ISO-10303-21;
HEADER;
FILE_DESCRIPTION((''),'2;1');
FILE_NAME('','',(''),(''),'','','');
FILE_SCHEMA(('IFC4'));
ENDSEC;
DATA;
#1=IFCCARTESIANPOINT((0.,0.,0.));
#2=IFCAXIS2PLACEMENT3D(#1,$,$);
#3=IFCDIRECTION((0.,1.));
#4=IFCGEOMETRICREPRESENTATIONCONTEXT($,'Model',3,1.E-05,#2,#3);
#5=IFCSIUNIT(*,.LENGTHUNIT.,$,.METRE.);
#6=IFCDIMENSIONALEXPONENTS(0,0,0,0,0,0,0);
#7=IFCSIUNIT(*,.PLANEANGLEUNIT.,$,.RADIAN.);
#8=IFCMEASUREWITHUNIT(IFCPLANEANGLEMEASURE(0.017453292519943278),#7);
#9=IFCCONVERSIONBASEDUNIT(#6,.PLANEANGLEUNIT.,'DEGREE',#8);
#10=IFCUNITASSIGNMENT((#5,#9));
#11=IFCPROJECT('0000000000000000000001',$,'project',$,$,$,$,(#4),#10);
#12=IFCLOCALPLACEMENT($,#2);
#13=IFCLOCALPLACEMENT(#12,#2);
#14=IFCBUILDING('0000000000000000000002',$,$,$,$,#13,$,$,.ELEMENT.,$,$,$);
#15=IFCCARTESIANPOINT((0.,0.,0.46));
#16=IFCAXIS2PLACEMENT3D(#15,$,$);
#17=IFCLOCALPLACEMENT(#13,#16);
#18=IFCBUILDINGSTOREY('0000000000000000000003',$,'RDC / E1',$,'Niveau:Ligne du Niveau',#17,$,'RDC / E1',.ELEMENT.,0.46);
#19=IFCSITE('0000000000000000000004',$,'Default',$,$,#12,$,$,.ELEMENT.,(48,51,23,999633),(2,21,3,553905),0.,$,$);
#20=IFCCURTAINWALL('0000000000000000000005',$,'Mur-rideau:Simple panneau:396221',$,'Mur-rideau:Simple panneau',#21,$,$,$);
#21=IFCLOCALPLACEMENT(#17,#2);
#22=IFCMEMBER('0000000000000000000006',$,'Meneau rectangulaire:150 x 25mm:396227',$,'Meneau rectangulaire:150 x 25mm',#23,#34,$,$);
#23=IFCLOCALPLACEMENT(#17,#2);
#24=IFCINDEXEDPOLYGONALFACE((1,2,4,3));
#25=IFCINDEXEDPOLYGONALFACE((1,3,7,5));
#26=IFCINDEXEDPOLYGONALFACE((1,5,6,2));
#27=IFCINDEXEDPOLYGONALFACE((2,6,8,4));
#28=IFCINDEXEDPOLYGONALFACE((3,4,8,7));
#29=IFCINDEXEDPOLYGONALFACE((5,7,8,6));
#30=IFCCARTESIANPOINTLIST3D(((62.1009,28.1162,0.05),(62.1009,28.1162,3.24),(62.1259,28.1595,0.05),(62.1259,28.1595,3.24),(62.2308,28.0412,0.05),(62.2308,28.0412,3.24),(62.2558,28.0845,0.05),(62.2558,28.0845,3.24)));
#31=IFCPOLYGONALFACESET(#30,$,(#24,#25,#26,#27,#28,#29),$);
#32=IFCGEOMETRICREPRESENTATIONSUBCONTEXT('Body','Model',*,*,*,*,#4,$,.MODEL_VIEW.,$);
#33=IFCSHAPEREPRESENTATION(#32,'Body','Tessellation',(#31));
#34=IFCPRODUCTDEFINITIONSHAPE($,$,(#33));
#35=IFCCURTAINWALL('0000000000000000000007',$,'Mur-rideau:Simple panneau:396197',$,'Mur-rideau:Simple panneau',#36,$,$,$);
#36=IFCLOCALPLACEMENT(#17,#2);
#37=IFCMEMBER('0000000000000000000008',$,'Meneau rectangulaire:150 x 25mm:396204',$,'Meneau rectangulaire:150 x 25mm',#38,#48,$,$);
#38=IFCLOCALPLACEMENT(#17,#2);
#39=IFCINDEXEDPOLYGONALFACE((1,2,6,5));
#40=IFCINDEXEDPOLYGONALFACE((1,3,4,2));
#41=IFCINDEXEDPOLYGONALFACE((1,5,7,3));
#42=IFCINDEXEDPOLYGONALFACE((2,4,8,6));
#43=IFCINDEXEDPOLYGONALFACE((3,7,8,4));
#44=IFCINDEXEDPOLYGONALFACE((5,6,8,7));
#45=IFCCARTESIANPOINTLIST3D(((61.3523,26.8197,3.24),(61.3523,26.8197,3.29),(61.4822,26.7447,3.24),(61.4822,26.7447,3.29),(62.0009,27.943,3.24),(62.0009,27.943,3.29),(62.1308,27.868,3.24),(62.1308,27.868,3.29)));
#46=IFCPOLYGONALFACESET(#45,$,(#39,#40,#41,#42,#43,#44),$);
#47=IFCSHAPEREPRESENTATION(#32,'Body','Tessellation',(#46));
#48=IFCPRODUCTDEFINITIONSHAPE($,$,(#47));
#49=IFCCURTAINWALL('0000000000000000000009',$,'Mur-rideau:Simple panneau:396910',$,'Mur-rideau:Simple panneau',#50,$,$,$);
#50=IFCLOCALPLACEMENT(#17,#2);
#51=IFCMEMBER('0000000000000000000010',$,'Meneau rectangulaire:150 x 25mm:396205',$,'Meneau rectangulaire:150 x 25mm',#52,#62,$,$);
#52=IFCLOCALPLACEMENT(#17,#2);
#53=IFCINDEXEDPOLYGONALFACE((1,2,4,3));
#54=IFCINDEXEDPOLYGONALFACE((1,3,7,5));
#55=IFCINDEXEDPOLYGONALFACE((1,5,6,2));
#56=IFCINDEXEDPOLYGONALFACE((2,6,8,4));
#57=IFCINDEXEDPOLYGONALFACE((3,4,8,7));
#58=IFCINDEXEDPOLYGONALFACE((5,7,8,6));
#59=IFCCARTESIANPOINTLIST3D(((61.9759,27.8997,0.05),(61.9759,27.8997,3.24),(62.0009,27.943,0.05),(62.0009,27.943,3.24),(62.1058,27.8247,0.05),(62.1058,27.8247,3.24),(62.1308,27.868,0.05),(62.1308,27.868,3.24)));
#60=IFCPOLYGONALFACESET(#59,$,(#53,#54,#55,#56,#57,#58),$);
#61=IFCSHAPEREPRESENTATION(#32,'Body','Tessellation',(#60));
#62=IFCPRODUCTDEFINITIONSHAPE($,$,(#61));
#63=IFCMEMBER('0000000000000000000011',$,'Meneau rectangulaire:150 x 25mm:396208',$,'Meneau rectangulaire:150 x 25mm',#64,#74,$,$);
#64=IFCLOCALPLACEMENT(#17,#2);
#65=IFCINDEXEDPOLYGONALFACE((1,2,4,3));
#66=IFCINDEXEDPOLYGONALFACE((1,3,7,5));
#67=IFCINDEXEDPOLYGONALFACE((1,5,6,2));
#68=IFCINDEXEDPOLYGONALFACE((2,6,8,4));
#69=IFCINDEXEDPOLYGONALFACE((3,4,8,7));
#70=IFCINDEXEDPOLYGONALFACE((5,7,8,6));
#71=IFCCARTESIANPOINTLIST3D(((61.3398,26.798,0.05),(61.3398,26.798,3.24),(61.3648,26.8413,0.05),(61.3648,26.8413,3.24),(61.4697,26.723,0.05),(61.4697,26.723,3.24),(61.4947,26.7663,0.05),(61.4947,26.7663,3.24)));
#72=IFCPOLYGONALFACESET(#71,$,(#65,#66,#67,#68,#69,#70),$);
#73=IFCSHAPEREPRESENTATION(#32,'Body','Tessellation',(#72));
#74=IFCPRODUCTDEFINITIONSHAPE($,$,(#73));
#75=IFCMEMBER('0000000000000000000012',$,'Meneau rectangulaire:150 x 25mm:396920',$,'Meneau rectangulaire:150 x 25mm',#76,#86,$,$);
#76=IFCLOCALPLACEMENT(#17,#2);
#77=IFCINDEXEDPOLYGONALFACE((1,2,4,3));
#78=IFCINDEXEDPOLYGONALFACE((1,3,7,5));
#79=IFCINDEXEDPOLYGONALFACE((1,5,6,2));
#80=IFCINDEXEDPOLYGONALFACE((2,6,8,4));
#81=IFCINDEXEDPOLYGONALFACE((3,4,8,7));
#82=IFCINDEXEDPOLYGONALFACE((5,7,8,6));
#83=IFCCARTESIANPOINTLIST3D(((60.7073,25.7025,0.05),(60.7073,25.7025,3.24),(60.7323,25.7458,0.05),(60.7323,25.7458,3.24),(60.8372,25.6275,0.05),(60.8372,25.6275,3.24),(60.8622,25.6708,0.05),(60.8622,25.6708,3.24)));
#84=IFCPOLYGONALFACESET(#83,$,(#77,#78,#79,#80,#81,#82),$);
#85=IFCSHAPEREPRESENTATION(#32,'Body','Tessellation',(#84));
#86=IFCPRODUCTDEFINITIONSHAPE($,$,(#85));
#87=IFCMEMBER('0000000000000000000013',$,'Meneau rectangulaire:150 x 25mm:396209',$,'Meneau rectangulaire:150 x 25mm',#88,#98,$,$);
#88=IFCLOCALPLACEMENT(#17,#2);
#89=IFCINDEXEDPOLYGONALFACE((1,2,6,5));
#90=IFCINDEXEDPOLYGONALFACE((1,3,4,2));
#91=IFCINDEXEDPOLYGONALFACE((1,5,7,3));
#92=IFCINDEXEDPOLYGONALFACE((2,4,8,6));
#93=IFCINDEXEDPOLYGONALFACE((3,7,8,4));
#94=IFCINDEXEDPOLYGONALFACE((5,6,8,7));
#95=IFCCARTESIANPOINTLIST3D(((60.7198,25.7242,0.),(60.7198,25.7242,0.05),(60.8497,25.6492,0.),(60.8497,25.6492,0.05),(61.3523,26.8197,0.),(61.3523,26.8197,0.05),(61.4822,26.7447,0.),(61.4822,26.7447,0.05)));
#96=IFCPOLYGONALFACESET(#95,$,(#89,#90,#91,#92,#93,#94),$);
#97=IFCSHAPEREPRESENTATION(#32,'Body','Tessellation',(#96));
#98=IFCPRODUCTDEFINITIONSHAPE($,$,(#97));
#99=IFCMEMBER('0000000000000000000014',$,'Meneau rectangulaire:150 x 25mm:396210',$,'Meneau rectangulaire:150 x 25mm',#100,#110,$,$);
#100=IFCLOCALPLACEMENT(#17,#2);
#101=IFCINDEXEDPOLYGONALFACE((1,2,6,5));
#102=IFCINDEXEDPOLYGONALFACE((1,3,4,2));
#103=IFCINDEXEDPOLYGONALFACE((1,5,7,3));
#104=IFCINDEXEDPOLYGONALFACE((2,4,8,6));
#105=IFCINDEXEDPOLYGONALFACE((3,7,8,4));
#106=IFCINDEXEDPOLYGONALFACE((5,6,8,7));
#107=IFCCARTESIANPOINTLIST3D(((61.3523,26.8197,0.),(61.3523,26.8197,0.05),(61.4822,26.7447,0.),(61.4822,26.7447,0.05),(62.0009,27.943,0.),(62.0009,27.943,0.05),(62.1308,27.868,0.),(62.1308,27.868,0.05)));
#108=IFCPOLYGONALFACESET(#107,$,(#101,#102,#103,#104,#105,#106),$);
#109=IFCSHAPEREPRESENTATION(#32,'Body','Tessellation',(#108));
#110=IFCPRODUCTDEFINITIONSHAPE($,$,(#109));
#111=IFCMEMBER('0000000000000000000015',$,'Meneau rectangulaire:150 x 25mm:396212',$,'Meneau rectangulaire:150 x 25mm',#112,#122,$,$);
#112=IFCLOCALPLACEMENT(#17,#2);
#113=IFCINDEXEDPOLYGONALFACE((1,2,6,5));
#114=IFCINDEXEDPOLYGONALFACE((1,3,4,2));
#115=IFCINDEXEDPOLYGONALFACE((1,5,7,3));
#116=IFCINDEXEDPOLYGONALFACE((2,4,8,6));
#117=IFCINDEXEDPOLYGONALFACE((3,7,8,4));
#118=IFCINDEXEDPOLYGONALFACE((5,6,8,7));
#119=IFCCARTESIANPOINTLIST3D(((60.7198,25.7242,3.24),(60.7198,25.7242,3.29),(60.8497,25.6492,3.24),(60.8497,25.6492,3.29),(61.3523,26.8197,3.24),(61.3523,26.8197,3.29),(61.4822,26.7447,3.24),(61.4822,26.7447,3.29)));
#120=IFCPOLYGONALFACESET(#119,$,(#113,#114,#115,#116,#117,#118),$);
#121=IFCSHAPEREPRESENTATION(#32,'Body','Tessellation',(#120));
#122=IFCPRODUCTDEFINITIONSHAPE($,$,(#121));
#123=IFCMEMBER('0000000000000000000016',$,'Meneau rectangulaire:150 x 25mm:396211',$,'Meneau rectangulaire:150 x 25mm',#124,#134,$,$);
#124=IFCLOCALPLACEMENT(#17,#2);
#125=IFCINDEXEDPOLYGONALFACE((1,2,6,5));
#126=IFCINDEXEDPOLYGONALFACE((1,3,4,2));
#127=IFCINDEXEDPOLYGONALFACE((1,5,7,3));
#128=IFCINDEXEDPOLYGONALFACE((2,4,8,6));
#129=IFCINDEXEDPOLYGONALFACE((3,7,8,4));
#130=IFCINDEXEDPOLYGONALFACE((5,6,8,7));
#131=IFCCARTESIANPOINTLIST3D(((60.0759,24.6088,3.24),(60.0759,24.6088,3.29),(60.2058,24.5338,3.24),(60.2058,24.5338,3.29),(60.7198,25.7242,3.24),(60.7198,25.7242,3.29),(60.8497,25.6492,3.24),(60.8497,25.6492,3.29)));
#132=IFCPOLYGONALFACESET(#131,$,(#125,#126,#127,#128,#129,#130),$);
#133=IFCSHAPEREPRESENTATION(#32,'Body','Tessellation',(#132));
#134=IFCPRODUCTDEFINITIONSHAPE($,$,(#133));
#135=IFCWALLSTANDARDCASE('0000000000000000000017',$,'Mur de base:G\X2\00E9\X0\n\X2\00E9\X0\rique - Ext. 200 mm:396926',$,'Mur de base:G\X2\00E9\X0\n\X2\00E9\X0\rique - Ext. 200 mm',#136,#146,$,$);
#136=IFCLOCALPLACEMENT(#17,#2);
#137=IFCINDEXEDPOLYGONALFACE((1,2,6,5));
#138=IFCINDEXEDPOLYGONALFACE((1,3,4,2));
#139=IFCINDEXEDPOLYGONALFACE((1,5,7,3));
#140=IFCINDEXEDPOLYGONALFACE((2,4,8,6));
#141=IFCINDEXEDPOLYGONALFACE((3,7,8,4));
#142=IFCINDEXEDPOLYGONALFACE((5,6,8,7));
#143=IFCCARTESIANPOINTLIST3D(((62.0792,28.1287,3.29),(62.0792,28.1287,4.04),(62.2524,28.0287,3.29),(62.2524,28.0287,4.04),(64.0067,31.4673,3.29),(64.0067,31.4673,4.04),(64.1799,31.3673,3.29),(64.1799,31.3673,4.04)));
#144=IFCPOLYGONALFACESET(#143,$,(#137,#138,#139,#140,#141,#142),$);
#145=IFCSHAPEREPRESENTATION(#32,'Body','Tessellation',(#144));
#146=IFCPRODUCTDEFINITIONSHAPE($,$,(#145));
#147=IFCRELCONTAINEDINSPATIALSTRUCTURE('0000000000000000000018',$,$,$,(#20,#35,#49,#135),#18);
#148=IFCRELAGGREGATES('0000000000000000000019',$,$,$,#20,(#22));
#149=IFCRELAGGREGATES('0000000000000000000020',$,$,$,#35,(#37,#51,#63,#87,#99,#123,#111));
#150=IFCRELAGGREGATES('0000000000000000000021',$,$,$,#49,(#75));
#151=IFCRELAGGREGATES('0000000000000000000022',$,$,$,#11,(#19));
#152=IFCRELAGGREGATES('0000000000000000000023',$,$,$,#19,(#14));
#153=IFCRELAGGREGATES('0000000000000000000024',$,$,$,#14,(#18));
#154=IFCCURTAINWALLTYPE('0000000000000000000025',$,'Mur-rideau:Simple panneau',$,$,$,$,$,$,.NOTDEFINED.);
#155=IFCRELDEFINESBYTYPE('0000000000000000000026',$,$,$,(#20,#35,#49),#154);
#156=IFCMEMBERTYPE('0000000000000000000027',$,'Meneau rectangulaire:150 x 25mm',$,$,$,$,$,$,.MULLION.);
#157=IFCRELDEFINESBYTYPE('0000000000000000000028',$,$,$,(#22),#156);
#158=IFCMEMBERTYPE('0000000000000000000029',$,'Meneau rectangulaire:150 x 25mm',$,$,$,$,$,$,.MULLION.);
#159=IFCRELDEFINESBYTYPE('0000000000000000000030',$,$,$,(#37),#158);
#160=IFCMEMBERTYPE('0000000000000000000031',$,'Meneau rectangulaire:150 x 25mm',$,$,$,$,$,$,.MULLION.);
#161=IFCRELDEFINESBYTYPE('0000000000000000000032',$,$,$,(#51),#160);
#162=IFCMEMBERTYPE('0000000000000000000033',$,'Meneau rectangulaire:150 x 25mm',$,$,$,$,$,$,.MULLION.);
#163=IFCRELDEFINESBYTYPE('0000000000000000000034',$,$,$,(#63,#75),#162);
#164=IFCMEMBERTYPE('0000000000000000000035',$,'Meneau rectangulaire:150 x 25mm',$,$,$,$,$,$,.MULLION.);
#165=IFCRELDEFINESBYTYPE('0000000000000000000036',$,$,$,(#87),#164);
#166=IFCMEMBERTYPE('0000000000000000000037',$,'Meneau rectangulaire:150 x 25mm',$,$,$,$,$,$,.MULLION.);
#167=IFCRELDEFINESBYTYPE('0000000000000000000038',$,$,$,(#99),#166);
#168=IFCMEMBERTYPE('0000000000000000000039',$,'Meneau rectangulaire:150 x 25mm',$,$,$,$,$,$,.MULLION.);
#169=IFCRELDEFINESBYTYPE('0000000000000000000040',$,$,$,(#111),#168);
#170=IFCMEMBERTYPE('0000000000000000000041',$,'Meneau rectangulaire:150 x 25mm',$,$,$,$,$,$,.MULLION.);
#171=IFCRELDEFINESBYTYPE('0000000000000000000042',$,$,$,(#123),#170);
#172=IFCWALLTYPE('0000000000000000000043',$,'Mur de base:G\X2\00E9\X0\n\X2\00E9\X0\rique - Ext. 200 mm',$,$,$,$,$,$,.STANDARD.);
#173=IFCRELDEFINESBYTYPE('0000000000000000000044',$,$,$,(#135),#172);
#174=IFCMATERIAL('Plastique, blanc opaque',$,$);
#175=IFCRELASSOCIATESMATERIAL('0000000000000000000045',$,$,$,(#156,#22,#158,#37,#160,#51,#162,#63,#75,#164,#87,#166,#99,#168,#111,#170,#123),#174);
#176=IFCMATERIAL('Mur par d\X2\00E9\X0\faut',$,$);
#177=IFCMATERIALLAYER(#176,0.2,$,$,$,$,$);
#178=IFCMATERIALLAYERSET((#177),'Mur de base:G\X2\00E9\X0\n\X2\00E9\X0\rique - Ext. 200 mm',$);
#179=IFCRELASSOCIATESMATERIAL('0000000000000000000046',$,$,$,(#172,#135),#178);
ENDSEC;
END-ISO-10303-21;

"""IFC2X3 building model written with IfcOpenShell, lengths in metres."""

from ifc_helpers import new_model, entity, si_unit, converted_unit, direction, frame, frame_2d, origin, origin_2d_with_axis, place, context, subcontext, project, spatial, rectangle, extrude, source, transform, mapped, material, layer, layer_set, layer_usage, type_object, type_shapes, element, aggregate, save


model = new_model("IFC2X3")

# Units and contexts
model_context = context("Model", 3, precision=1e-05, world=origin(), true_north=direction((0.0, 1.0)))
body_context = subcontext(model_context, "Body", "Model", "MODEL_VIEW")
ifc_project = project(units=[si_unit("LENGTHUNIT", "METRE"), converted_unit("PLANEANGLEUNIT", "DEGREE", entity("IfcPlaneAngleMeasure", 0.017453292519943278), si_unit("PLANEANGLEUNIT", "RADIAN"), dimensions=[0, 0, 0, 0, 0, 0, 0])], contexts=[model_context])

# Site, building, storey
site_placement = place(None, origin())
site = spatial("IfcSite", under=ifc_project, at=site_placement, Name="Default", CompositionType="ELEMENT", RefLatitude=(48, 51, 23, 999633), RefLongitude=(2, 21, 3, 553905), RefElevation=0.0)
building_placement = place(site_placement, origin())
building = spatial("IfcBuilding", under=site, at=building_placement, CompositionType="ELEMENT")
storey_placement = place(building_placement, frame((0.0, 0.0, 0.46)))
storey = spatial("IfcBuildingStorey", under=building, at=storey_placement, Name="RDC / E1", ObjectType="Niveau:Ligne du Niveau", LongName="RDC / E1", CompositionType="ELEMENT", Elevation=0.46)

# Curtain walls, members
curtain_wall_type = type_object("IfcCurtainWallType", Name="Mur-rideau:Simple panneau", PredefinedType="NOTDEFINED")
curtain_wall_1_placement = place(storey_placement, frame((0.0, 0.0, -0.46)))
curtain_wall_1 = element("IfcCurtainWall", 1, at=curtain_wall_1_placement, inside=storey, type_object=curtain_wall_type, Name="Mur-rideau:Simple panneau:396221", ObjectType="Mur-rideau:Simple panneau")
ifc_material_1 = material(Name="Plastique, blanc opaque")
member_type_1 = type_object("IfcMemberType", Name="Meneau rectangulaire:150 x 25mm", PredefinedType="MULLION", material=ifc_material_1)
shared_shape_1 = source(origin(), body_context, "Body", "SweptSolid", [
    extrude(rectangle(XDim=0.05, YDim=0.15, at=origin_2d_with_axis()), frame((-0.025, 0.0, -3.19), z_axis=(0.0, 0.0, 1.0), x_axis=(-1.0, 0.0, 0.0)), (0.0, 0.0, 1.0), 3.19),
])
type_shapes(member_type_1, [shared_shape_1])
member_1_placement = place(curtain_wall_1_placement, frame((62.1658, 28.0787, 3.7), z_axis=(0.0, 0.0, 1.0), x_axis=(-0.5, -0.866025, 0.0)))
member_1 = element("IfcMember", 2, at=member_1_placement, type_object=member_type_1, material=ifc_material_1, Name="Meneau rectangulaire:150 x 25mm:396227", ObjectType="Meneau rectangulaire:150 x 25mm", context=body_context, shape_type="MappedRepresentation", body=[
    mapped(shared_shape_1, transform((0.0, 0.0, 0.0), scale=1.0)),
])
aggregate(curtain_wall_1, [member_1])
curtain_wall_2_placement = place(storey_placement, frame((0.0, 0.0, -0.46)))
curtain_wall_2 = element("IfcCurtainWall", 3, at=curtain_wall_2_placement, inside=storey, type_object=curtain_wall_type, Name="Mur-rideau:Simple panneau:396197", ObjectType="Mur-rideau:Simple panneau")
member_type_2 = type_object("IfcMemberType", Name="Meneau rectangulaire:150 x 25mm", PredefinedType="MULLION", material=ifc_material_1)
shared_shape_2 = source(origin(), body_context, "Body", "SweptSolid", [
    extrude(rectangle(XDim=0.05, YDim=0.15, at=origin_2d_with_axis()), frame((-0.025, 0.0, -1.2971), z_axis=(0.0, 0.0, 1.0), x_axis=(-1.0, 0.0, 0.0)), (0.0, 0.0, 1.0), 1.2971),
])
type_shapes(member_type_2, [shared_shape_2])
member_2_placement = place(curtain_wall_2_placement, frame((62.0658, 27.9055, 3.75), z_axis=(0.5, 0.866025, 0.0), x_axis=(0.0, 0.0, 1.0)))
member_2 = element("IfcMember", 4, at=member_2_placement, type_object=member_type_2, material=ifc_material_1, Name="Meneau rectangulaire:150 x 25mm:396204", ObjectType="Meneau rectangulaire:150 x 25mm", context=body_context, shape_type="MappedRepresentation", body=[
    mapped(shared_shape_2, transform((0.0, 0.0, 0.0), scale=1.0)),
])
curtain_wall_3_placement = place(storey_placement, frame((0.0, 0.0, -0.46)))
curtain_wall_3 = element("IfcCurtainWall", 5, at=curtain_wall_3_placement, inside=storey, type_object=curtain_wall_type, Name="Mur-rideau:Simple panneau:396910", ObjectType="Mur-rideau:Simple panneau")

# Members
member_type_3 = type_object("IfcMemberType", Name="Meneau rectangulaire:150 x 25mm", PredefinedType="MULLION", material=ifc_material_1)
shared_shape_3 = source(origin(), body_context, "Body", "SweptSolid", [
    extrude(rectangle(XDim=0.05, YDim=0.15, at=origin_2d_with_axis()), frame((-0.025, 0.0, -3.19), z_axis=(0.0, 0.0, 1.0), x_axis=(-1.0, 0.0, 0.0)), (0.0, 0.0, 1.0), 3.19),
])
type_shapes(member_type_3, [shared_shape_3])
member_3_placement = place(curtain_wall_2_placement, frame((62.0658, 27.9055, 0.51), z_axis=(0.0, 0.0, -1.0), x_axis=(0.5, 0.866025, 0.0)))
member_3 = element("IfcMember", 6, at=member_3_placement, type_object=member_type_3, material=ifc_material_1, Name="Meneau rectangulaire:150 x 25mm:396205", ObjectType="Meneau rectangulaire:150 x 25mm", context=body_context, shape_type="MappedRepresentation", body=[
    mapped(shared_shape_3, transform((0.0, 0.0, 0.0), scale=1.0)),
])
member_type_4 = type_object("IfcMemberType", Name="Meneau rectangulaire:150 x 25mm", PredefinedType="MULLION", material=ifc_material_1)
shared_shape_4 = source(origin(), body_context, "Body", "SweptSolid", [
    extrude(rectangle(XDim=0.05, YDim=0.15, at=origin_2d_with_axis()), frame((0.0, 0.0, -3.19), z_axis=(0.0, 0.0, 1.0), x_axis=(-1.0, 0.0, 0.0)), (0.0, 0.0, 1.0), 3.19),
])
type_shapes(member_type_4, [shared_shape_4])
member_4_placement = place(curtain_wall_2_placement, frame((61.4172, 26.7822, 0.51), z_axis=(0.0, 0.0, -1.0), x_axis=(0.5, 0.866025, 0.0)))
member_4 = element("IfcMember", 7, at=member_4_placement, type_object=member_type_4, material=ifc_material_1, Name="Meneau rectangulaire:150 x 25mm:396208", ObjectType="Meneau rectangulaire:150 x 25mm", context=body_context, shape_type="MappedRepresentation", body=[
    mapped(shared_shape_4, transform((0.0, 0.0, 0.0), scale=1.0)),
])
member_5_placement = place(curtain_wall_3_placement, frame((60.7847, 25.6867, 0.51), z_axis=(0.0, 0.0, -1.0), x_axis=(0.5, 0.866025, 0.0)))
member_5 = element("IfcMember", 8, at=member_5_placement, type_object=member_type_4, material=ifc_material_1, Name="Meneau rectangulaire:150 x 25mm:396920", ObjectType="Meneau rectangulaire:150 x 25mm", context=body_context, shape_type="MappedRepresentation", body=[
    mapped(shared_shape_4, transform((0.0, 0.0, 0.0), scale=1.0)),
])
member_type_5 = type_object("IfcMemberType", Name="Meneau rectangulaire:150 x 25mm", PredefinedType="MULLION", material=ifc_material_1)
shared_shape_5 = source(origin(), body_context, "Body", "SweptSolid", [
    extrude(rectangle(XDim=0.05, YDim=0.15, at=origin_2d_with_axis()), frame((-0.025, 0.0, -1.265), z_axis=(0.0, 0.0, 1.0), x_axis=(-1.0, 0.0, 0.0)), (0.0, 0.0, 1.0), 1.265),
])
type_shapes(member_type_5, [shared_shape_5])
member_6_placement = place(curtain_wall_2_placement, frame((60.7847, 25.6867, 0.46), z_axis=(-0.5, -0.866025, 0.0), x_axis=(0.0, 0.0, -1.0)))
member_6 = element("IfcMember", 9, at=member_6_placement, type_object=member_type_5, material=ifc_material_1, Name="Meneau rectangulaire:150 x 25mm:396209", ObjectType="Meneau rectangulaire:150 x 25mm", context=body_context, shape_type="MappedRepresentation", body=[
    mapped(shared_shape_5, transform((0.0, 0.0, 0.0), scale=1.0)),
])
member_type_6 = type_object("IfcMemberType", Name="Meneau rectangulaire:150 x 25mm", PredefinedType="MULLION", material=ifc_material_1)
shared_shape_6 = source(origin(), body_context, "Body", "SweptSolid", [
    extrude(rectangle(XDim=0.05, YDim=0.15, at=origin_2d_with_axis()), frame((-0.025, 0.0, -1.2971), z_axis=(0.0, 0.0, 1.0), x_axis=(-1.0, 0.0, 0.0)), (0.0, 0.0, 1.0), 1.2971),
])
type_shapes(member_type_6, [shared_shape_6])
member_7_placement = place(curtain_wall_2_placement, frame((61.4172, 26.7822, 0.46), z_axis=(-0.5, -0.866025, 0.0), x_axis=(0.0, 0.0, -1.0)))
member_7 = element("IfcMember", 10, at=member_7_placement, type_object=member_type_6, material=ifc_material_1, Name="Meneau rectangulaire:150 x 25mm:396210", ObjectType="Meneau rectangulaire:150 x 25mm", context=body_context, shape_type="MappedRepresentation", body=[
    mapped(shared_shape_6, transform((0.0, 0.0, 0.0), scale=1.0)),
])
member_type_7 = type_object("IfcMemberType", Name="Meneau rectangulaire:150 x 25mm", PredefinedType="MULLION", material=ifc_material_1)
shared_shape_7 = source(origin(), body_context, "Body", "SweptSolid", [
    extrude(rectangle(XDim=0.05, YDim=0.15, at=origin_2d_with_axis()), frame((-0.025, 0.0, -1.265), z_axis=(0.0, 0.0, 1.0), x_axis=(-1.0, 0.0, 0.0)), (0.0, 0.0, 1.0), 1.265),
])
type_shapes(member_type_7, [shared_shape_7])
member_8_placement = place(curtain_wall_2_placement, frame((61.4172, 26.7822, 3.75), z_axis=(0.5, 0.866025, 0.0), x_axis=(0.0, 0.0, 1.0)))
member_8 = element("IfcMember", 11, at=member_8_placement, type_object=member_type_7, material=ifc_material_1, Name="Meneau rectangulaire:150 x 25mm:396212", ObjectType="Meneau rectangulaire:150 x 25mm", context=body_context, shape_type="MappedRepresentation", body=[
    mapped(shared_shape_7, transform((0.0, 0.0, 0.0), scale=1.0)),
])
member_type_8 = type_object("IfcMemberType", Name="Meneau rectangulaire:150 x 25mm", PredefinedType="MULLION", material=ifc_material_1)
shared_shape_8 = source(origin(), body_context, "Body", "SweptSolid", [
    extrude(rectangle(XDim=0.05, YDim=0.15, at=origin_2d_with_axis()), frame((-0.025, 0.0, -1.2879), z_axis=(0.0, 0.0, 1.0), x_axis=(-1.0, 0.0, 0.0)), (0.0, 0.0, 1.0), 1.2879),
])
type_shapes(member_type_8, [shared_shape_8])
member_9_placement = place(curtain_wall_2_placement, frame((60.7847, 25.6867, 3.75), z_axis=(0.5, 0.866025, 0.0), x_axis=(0.0, 0.0, 1.0)))
member_9 = element("IfcMember", 12, at=member_9_placement, type_object=member_type_8, material=ifc_material_1, Name="Meneau rectangulaire:150 x 25mm:396211", ObjectType="Meneau rectangulaire:150 x 25mm", context=body_context, shape_type="MappedRepresentation", body=[
    mapped(shared_shape_8, transform((0.0, 0.0, 0.0), scale=1.0)),
])

aggregate(curtain_wall_2, [member_2, member_3, member_4, member_6, member_7, member_9, member_8])
aggregate(curtain_wall_3, [member_5])

# Wall, opening
ifc_material_2 = material(Name="Mur par défaut")
ifc_layer_1 = layer(ifc_material_2, 0.2)
ifc_layer_set_1 = layer_set([ifc_layer_1], Name="Mur de base:Générique - Ext. 200 mm")
ifc_layer_usage = layer_usage(ifc_layer_set_1, "AXIS2", "NEGATIVE", 0.1)
wall_type = type_object("IfcWallType", Name="Mur de base:Générique - Ext. 200 mm", PredefinedType="STANDARD", material=ifc_layer_set_1)
wall_placement = place(storey_placement, frame((62.1658, 28.0787, 3.29), z_axis=(0.0, 0.0, 1.0), x_axis=(0.5, 0.866025, 0.0)))
wall = element("IfcWallStandardCase", 13, at=wall_placement, inside=storey, type_object=wall_type, material=ifc_layer_usage, Name="Mur de base:Générique - Ext. 200 mm:396926", ObjectType="Mur de base:Générique - Ext. 200 mm", context=body_context, shape_type="SweptSolid", body=[
    extrude(rectangle(XDim=3.855, YDim=0.2, at=frame_2d((1.9275, 0.0), x_axis=(1.0, 0.0))), origin(), (0.0, 0.0, 1.0), 0.75),
])
opening_placement = place(wall_placement, origin())
element("IfcOpeningElement", 14, at=opening_placement, cuts=wall, ObjectType="Opening", context=body_context, shape_type="SweptSolid", body=[
    extrude(rectangle(XDim=3.29, YDim=3.855, at=frame_2d((0.0, 0.0), x_axis=(1.0, 0.0))), frame((1.9275, -0.2524, -1.645), z_axis=(0.0, 1.0, 0.0), x_axis=(0.0, 0.0, 1.0)), (0.0, 0.0, 1.0), 0.5048),
])

save(model, "model.ifc")
